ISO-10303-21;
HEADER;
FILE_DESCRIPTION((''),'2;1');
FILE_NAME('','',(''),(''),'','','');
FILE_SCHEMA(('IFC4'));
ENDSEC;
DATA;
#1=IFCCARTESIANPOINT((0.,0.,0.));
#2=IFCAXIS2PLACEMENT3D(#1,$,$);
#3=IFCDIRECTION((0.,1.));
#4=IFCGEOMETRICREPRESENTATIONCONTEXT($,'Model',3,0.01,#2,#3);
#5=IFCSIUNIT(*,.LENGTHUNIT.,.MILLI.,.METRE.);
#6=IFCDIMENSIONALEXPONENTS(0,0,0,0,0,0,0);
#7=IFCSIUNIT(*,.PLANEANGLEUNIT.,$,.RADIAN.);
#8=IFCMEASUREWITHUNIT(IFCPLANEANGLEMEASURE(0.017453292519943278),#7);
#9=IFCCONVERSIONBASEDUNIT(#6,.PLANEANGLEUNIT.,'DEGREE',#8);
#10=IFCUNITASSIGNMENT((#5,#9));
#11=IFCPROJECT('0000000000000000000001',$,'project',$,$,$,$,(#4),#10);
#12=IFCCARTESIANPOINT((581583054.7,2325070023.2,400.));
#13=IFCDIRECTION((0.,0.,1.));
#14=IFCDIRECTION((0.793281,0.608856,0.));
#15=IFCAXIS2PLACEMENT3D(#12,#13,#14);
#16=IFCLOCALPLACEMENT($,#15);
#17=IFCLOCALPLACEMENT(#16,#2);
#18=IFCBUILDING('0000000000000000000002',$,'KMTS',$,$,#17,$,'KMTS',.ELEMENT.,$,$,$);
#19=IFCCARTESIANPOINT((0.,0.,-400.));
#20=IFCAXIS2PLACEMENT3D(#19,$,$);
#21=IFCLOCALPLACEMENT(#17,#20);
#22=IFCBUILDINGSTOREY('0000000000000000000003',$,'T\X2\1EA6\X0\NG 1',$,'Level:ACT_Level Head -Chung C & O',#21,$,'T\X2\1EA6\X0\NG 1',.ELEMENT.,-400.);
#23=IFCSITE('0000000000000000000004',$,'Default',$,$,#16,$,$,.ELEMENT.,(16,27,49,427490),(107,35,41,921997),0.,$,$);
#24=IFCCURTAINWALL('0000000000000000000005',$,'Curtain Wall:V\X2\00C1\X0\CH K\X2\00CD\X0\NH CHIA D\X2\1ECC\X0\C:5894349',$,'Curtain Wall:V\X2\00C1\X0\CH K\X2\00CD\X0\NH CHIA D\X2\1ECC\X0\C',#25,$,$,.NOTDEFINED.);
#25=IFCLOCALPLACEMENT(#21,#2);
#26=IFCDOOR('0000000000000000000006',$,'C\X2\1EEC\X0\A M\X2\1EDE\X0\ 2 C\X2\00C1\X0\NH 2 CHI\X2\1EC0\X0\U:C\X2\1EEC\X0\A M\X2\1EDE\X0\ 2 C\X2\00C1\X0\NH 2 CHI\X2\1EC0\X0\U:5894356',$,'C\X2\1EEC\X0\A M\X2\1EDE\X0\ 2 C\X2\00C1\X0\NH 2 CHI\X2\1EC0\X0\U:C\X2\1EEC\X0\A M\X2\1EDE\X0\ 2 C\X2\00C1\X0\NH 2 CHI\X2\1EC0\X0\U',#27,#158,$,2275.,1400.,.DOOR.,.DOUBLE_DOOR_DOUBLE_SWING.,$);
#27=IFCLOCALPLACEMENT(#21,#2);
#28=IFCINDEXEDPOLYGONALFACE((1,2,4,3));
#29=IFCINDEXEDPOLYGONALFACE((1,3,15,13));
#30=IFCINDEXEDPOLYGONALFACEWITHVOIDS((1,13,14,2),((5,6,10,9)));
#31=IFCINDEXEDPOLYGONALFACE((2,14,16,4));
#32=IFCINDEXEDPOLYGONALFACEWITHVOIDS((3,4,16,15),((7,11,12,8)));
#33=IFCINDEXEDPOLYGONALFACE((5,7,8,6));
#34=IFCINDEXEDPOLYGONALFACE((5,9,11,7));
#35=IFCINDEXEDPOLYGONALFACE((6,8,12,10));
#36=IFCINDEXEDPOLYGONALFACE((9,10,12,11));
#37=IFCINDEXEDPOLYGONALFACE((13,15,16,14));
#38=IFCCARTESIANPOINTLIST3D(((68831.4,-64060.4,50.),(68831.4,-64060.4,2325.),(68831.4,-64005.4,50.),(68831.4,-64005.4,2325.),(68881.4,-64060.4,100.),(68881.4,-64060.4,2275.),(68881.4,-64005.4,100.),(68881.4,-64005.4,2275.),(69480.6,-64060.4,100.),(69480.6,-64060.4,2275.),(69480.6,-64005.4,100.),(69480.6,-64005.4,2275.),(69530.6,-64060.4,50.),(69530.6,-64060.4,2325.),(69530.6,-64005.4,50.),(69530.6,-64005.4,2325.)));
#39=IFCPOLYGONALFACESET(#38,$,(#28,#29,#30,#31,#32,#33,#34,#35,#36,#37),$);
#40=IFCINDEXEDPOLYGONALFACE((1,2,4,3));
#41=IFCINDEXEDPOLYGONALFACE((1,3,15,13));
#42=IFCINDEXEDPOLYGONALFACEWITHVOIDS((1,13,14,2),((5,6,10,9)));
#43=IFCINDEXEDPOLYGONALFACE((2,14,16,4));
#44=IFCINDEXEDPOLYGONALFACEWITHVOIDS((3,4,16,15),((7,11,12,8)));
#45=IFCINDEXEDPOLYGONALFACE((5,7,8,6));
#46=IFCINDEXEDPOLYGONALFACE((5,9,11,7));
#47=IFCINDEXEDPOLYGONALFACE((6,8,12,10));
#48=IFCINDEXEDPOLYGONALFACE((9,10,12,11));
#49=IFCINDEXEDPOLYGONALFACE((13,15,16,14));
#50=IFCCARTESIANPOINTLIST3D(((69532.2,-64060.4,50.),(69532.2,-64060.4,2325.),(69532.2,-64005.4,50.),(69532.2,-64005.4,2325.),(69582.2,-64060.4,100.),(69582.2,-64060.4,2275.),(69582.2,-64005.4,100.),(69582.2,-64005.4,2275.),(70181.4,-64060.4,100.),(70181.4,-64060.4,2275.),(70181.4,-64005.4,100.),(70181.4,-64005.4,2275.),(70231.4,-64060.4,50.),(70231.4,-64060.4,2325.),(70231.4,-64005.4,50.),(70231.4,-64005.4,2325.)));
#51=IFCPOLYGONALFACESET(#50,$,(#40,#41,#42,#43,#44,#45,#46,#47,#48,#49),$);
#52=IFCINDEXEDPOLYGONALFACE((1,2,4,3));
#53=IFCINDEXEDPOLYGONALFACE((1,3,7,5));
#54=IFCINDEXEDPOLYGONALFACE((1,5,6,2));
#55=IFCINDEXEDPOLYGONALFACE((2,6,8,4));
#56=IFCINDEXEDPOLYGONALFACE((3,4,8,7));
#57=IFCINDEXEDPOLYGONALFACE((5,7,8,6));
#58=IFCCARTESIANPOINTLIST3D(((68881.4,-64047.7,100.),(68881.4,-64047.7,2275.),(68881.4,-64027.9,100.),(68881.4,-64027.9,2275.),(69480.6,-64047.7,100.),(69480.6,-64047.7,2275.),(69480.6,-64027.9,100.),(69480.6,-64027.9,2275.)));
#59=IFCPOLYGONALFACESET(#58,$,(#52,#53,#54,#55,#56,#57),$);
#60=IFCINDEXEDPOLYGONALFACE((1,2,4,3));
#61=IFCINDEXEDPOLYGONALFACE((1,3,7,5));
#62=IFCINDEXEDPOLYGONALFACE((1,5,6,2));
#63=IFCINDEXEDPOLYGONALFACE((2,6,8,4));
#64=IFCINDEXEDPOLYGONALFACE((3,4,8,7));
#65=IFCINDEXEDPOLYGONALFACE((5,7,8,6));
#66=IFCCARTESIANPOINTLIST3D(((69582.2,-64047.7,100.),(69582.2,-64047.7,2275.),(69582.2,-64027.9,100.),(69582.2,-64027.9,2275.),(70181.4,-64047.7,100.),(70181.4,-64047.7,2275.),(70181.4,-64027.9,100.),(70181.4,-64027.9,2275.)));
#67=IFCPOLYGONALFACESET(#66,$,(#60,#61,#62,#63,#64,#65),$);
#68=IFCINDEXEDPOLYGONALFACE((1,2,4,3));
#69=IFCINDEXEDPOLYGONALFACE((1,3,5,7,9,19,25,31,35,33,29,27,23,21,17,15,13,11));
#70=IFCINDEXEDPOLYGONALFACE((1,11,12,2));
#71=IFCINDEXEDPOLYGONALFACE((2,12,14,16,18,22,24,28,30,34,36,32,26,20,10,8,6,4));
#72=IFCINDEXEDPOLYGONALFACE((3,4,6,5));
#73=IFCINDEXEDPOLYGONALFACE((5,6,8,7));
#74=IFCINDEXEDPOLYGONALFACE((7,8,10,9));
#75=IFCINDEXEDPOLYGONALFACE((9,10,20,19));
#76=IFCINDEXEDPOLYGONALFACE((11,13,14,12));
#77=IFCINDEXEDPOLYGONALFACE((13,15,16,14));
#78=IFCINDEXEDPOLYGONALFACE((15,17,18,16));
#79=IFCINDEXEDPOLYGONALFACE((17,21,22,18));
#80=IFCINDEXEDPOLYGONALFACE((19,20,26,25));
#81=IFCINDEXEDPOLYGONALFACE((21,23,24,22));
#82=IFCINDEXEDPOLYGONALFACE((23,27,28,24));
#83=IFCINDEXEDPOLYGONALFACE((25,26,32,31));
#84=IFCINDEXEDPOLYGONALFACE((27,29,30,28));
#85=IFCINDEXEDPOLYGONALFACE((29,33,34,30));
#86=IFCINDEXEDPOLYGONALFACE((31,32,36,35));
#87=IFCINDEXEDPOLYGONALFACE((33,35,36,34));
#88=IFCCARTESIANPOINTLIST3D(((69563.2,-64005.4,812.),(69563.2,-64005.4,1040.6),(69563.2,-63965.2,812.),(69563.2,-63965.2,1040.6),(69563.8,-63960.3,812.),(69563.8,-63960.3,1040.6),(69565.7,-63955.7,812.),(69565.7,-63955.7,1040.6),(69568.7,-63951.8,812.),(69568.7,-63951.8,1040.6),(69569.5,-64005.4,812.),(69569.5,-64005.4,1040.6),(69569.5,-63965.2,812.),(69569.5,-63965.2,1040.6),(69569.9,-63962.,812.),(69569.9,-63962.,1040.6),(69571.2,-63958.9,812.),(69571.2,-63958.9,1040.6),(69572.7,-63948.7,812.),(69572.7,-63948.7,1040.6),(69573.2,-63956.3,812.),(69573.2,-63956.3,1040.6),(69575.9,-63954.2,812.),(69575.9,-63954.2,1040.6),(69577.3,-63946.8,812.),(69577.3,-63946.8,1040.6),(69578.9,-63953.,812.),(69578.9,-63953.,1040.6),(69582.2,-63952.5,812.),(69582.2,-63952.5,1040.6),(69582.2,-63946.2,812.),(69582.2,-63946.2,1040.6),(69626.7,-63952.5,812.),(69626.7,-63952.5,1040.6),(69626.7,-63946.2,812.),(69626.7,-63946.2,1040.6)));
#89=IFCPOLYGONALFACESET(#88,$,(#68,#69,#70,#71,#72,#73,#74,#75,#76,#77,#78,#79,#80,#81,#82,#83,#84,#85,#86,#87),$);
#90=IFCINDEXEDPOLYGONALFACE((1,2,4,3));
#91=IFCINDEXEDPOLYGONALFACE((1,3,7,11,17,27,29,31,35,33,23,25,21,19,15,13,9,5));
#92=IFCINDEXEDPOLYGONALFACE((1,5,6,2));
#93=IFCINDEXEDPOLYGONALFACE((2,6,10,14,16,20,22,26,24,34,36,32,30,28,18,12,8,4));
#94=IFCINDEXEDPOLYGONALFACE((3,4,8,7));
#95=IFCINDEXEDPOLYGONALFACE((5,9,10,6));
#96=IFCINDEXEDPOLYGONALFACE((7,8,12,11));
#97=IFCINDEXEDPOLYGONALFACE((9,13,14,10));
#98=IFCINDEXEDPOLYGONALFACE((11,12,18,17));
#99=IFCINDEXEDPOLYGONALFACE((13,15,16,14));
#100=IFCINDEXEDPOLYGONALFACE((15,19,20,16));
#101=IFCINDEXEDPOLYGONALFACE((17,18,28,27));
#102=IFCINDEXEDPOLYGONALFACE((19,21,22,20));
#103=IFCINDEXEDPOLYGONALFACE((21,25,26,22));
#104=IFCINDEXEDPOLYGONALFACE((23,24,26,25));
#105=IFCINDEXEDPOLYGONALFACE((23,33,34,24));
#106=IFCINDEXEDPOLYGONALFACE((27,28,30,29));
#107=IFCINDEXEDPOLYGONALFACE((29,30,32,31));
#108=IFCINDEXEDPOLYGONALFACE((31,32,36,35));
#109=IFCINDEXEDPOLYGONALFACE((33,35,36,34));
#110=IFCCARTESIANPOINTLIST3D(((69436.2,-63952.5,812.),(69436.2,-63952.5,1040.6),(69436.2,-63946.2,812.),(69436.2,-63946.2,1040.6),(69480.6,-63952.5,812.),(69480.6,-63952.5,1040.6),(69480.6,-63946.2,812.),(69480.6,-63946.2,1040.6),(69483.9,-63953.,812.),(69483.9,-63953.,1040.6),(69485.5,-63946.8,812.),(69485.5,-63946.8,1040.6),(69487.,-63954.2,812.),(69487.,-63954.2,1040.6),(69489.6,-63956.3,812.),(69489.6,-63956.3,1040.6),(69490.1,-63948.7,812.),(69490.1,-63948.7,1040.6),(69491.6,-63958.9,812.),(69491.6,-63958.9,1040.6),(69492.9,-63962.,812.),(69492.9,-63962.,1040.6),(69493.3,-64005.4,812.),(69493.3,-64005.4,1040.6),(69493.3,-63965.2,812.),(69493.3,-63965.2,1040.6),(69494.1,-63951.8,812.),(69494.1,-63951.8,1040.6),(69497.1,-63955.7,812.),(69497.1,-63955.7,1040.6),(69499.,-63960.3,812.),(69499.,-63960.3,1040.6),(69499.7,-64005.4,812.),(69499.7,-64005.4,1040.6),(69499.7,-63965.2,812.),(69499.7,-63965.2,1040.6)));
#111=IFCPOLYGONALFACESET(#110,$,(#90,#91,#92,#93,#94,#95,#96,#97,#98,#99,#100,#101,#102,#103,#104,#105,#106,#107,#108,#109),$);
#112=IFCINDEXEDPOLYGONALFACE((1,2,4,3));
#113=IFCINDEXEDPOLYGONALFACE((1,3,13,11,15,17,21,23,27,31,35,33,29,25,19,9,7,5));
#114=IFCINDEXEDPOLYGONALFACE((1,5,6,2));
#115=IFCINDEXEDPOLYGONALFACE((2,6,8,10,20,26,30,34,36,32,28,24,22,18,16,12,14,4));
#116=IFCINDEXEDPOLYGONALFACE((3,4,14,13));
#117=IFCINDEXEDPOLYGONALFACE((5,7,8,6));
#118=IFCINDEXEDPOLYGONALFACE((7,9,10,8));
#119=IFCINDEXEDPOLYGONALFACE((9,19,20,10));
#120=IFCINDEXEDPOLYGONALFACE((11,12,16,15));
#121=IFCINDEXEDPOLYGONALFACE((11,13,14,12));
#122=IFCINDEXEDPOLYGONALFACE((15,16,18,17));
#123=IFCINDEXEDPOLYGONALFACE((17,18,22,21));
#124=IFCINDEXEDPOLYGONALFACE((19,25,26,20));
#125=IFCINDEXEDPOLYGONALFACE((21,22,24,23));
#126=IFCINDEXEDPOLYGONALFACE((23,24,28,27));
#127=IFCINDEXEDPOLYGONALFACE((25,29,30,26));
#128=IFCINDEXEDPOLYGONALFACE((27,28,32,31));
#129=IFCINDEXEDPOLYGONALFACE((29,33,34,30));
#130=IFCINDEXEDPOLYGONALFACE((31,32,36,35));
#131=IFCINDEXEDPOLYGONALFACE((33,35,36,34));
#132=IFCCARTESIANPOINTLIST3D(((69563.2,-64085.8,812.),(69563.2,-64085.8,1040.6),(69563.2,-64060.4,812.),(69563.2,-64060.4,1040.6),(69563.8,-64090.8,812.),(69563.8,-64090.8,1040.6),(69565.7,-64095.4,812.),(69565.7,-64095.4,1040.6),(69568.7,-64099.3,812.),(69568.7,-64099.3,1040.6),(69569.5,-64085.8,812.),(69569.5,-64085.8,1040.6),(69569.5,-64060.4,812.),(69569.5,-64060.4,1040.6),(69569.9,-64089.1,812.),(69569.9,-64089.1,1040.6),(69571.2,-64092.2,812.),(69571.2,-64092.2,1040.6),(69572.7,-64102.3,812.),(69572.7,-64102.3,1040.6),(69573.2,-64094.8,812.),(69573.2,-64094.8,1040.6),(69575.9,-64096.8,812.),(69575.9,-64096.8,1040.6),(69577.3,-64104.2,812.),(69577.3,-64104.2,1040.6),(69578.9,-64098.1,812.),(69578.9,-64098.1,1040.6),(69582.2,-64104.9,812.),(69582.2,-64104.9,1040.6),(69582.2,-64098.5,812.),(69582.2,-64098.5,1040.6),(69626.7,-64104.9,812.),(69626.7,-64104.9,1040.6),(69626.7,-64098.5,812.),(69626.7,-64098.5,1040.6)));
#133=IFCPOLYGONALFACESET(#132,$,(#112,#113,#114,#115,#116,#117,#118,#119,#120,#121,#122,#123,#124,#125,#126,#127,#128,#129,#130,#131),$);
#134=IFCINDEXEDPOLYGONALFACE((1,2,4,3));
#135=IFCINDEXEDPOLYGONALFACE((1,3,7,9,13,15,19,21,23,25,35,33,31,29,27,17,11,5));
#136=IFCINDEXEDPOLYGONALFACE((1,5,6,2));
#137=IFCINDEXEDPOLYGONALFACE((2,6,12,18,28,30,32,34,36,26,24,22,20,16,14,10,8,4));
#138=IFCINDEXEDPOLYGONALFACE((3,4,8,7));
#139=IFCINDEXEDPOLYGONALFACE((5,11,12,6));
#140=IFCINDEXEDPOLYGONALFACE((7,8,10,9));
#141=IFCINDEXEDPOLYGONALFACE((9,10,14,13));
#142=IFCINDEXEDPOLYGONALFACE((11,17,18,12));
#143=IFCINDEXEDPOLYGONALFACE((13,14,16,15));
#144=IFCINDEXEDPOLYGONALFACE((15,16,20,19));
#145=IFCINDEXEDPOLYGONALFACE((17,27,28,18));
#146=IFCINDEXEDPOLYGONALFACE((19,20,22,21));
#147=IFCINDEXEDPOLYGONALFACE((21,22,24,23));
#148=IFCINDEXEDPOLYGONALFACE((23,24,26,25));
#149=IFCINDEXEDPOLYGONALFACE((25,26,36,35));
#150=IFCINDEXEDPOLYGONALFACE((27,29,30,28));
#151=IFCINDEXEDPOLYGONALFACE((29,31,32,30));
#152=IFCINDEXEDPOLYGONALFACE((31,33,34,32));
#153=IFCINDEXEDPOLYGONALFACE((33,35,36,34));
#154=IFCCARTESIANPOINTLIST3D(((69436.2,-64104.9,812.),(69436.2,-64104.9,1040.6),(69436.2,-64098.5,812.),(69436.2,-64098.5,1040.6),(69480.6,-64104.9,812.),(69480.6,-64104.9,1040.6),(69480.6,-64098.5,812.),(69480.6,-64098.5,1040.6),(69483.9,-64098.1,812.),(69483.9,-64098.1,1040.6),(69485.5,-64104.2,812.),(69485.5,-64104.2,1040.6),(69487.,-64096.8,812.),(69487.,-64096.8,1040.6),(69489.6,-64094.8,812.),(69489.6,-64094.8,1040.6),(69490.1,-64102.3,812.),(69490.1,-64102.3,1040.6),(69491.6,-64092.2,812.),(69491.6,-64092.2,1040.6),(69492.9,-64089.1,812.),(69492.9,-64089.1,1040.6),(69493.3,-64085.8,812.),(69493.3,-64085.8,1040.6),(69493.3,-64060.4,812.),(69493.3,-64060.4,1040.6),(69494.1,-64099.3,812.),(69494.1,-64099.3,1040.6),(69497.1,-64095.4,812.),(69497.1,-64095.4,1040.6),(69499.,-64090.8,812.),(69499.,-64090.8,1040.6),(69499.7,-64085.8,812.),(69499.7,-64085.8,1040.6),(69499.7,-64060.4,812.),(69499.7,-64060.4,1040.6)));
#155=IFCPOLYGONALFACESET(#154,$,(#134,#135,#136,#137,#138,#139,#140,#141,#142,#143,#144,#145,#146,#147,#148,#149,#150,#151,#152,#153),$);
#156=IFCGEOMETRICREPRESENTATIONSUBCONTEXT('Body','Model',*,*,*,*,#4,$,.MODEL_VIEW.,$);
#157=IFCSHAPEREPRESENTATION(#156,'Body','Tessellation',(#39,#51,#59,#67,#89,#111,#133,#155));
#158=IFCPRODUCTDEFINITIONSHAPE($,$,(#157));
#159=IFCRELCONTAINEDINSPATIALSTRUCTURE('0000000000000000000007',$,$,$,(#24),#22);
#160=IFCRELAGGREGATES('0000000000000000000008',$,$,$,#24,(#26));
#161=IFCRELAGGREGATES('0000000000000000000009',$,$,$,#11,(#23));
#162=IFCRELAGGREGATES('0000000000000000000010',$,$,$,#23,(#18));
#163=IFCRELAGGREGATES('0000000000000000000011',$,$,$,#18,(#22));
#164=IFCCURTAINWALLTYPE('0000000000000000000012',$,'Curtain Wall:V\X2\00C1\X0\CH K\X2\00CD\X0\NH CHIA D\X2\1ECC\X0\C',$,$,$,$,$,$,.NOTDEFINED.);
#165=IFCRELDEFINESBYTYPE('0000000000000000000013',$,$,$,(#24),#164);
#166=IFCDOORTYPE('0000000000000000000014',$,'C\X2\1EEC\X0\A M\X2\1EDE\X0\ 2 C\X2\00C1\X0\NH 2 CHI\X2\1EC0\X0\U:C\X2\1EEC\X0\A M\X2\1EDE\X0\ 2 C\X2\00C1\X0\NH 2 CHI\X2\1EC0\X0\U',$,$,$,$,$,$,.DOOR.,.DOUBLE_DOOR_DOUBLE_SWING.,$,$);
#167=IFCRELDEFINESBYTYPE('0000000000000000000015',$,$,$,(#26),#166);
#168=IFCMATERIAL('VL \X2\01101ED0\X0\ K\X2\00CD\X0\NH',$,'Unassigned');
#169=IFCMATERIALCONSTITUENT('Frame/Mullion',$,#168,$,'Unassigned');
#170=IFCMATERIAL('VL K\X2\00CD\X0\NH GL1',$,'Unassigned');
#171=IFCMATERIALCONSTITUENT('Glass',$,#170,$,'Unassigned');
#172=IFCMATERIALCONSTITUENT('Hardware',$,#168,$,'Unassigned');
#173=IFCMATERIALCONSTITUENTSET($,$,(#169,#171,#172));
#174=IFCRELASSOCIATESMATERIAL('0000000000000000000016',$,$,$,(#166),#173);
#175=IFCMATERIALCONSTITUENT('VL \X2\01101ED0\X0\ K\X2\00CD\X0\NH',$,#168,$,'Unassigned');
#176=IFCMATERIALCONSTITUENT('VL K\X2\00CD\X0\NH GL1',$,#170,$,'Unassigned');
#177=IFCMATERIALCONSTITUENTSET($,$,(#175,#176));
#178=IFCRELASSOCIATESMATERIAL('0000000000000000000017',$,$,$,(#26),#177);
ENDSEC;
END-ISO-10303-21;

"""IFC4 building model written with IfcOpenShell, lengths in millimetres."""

from ifc_helpers import new_model, entity, si_unit, converted_unit, direction, frame, origin, place, context, subcontext, project, spatial, line, arc, indexed_curve, outline, extrude, source, transform, mapped, material, constituent, constituent_set, type_object, type_shapes, element, aggregate, save


model = new_model("IFC4")

# Units and contexts
model_context = context("Model", 3, precision=0.01, world=origin(), true_north=direction((0.0, 1.0)))
body_context = subcontext(model_context, "Body", "Model", "MODEL_VIEW")
ifc_project = project(units=[si_unit("LENGTHUNIT", "METRE", prefix="MILLI"), converted_unit("PLANEANGLEUNIT", "DEGREE", entity("IfcPlaneAngleMeasure", 0.017453292519943278), si_unit("PLANEANGLEUNIT", "RADIAN"), dimensions=[0, 0, 0, 0, 0, 0, 0])], contexts=[model_context])

# Site, building, storey
site_placement = place(None, frame((581583054.7, 2325070023.2, 400.0), z_axis=(0.0, 0.0, 1.0), x_axis=(0.793281, 0.608856, 0.0)))
site = spatial("IfcSite", under=ifc_project, at=site_placement, Name="Default", CompositionType="ELEMENT", RefLatitude=(16, 27, 49, 427490), RefLongitude=(107, 35, 41, 921997), RefElevation=0.0)
building_placement = place(site_placement, origin())
building = spatial("IfcBuilding", under=site, at=building_placement, Name="KMTS", LongName="KMTS", CompositionType="ELEMENT")
storey_placement = place(building_placement, frame((0.0, 0.0, -400.0)))
storey = spatial("IfcBuildingStorey", under=building, at=storey_placement, Name="TẦNG 1", ObjectType="Level:ACT_Level Head -Chung C & O", LongName="TẦNG 1", CompositionType="ELEMENT", Elevation=-400.0)

# Curtain wall
curtain_wall_type = type_object("IfcCurtainWallType", Name="Curtain Wall:VÁCH KÍNH CHIA DỌC", PredefinedType="NOTDEFINED")
curtain_wall_1_placement = place(storey_placement, frame((0.0, 0.0, 400.0)))
curtain_wall_1 = element("IfcCurtainWall", 1, at=curtain_wall_1_placement, inside=storey, type_object=curtain_wall_type, Name="Curtain Wall:VÁCH KÍNH CHIA DỌC:5894349", ObjectType="Curtain Wall:VÁCH KÍNH CHIA DỌC", PredefinedType="NOTDEFINED")
ifc_material_1 = material(Name="VL ĐỐ KÍNH", Category="Unassigned")

# Door
ifc_constituent_1 = constituent(ifc_material_1, Name="VL ĐỐ KÍNH", Category="Unassigned")
ifc_material_2 = material(Name="VL KÍNH GL1", Category="Unassigned")
ifc_constituent_2 = constituent(ifc_material_2, Name="VL KÍNH GL1", Category="Unassigned")
ifc_constituent_set_1 = constituent_set(constituents=[ifc_constituent_1, ifc_constituent_2])
ifc_constituent_3 = constituent(ifc_material_1, Name="Frame/Mullion", Category="Unassigned")
ifc_constituent_4 = constituent(ifc_material_2, Name="Glass", Category="Unassigned")
ifc_constituent_5 = constituent(ifc_material_1, Name="Hardware", Category="Unassigned")
ifc_constituent_set_2 = constituent_set(constituents=[ifc_constituent_3, ifc_constituent_4, ifc_constituent_5])
door_type_1 = type_object("IfcDoorType", Name="CỬA MỞ 2 CÁNH 2 CHIỀU:CỬA MỞ 2 CÁNH 2 CHIỀU", OperationType="DOUBLE_DOOR_DOUBLE_SWING", PredefinedType="DOOR", material=ifc_constituent_set_2)
shared_shape_1 = source(origin(), body_context, "Body", "SweptSolid", [
    extrude(outline(indexed_curve([(-1137.5, -349.6), (1137.5, -349.6), (1137.5, 349.6), (-1137.5, 349.6), (-1137.5, -349.6)], self_intersect=False), holes=[indexed_curve([(-1087.5, 299.6), (1087.5, 299.6), (1087.5, -299.6), (-1087.5, -299.6), (-1087.5, 299.6)], self_intersect=False)]), frame((350.4, 27.5, 1137.5), z_axis=(0.0, -1.0, 0.0), x_axis=(0.0, 0.0, -1.0)), (0.0, 0.0, 1.0), 55.0),
    extrude(outline(indexed_curve([(-349.6, -1137.5), (349.6, -1137.5), (349.6, 1137.5), (-349.6, 1137.5), (-349.6, -1137.5)], self_intersect=False), holes=[indexed_curve([(-299.6, -1087.5), (-299.6, 1087.5), (299.6, 1087.5), (299.6, -1087.5), (-299.6, -1087.5)], self_intersect=False)]), frame((-350.4, 27.5, 1137.5), z_axis=(0.0, -1.0, 0.0), x_axis=(-1.0, 0.0, 0.0)), (0.0, 0.0, 1.0), 55.0),
    extrude(outline(indexed_curve([(-299.6, -9.9), (299.6, -9.9), (299.6, 9.9), (-299.6, 9.9), (-299.6, -9.9)], self_intersect=False)), frame((350.4, 4.9, 50.0)), (0.0, 0.0, 1.0), 2175.0),
    extrude(outline(indexed_curve([(-299.6, -9.9), (299.6, -9.9), (299.6, 9.9), (-299.6, 9.9), (-299.6, -9.9)], self_intersect=False)), frame((-350.4, 4.9, 50.0)), (0.0, 0.0, 1.0), 2175.0),
    extrude(outline(indexed_curve([(-2.1, -22.2), (38.1, -22.2), (38.1, -15.9), (-2.1, -15.9), (-11.1, -12.2), (-14.8, -3.2), (-14.8, 41.3), (-21.2, 41.3), (-21.2, -3.2), (-15.6, -16.6)], segments=[line(1, 2, 3, 4), arc(4, 5, 6), line(6, 7, 8, 9), arc(9, 10, 1)], self_intersect=False)), frame((-54.0, -65.6, 762.0), z_axis=(0.0, 0.0, 1.0), x_axis=(0.0, 1.0, 0.0)), (0.0, 0.0, 1.0), 228.6),
    extrude(outline(indexed_curve([(22.2, 2.1), (16.6, 15.6), (3.2, 21.2), (-41.3, 21.2), (-41.3, 14.8), (3.2, 14.8), (12.2, 11.1), (15.9, 2.1), (15.9, -38.1), (22.2, -38.1)], segments=[arc(1, 2, 3), line(3, 4, 5, 6), arc(6, 7, 8), line(8, 9, 10, 1)], self_intersect=False)), frame((54.0, -65.6, 762.0), z_axis=(0.0, 0.0, 1.0), x_axis=(-1.0, 0.0, 0.0)), (0.0, 0.0, 1.0), 228.6),
    extrude(outline(indexed_curve([(-22.2, 1.6), (-16.6, -11.9), (-3.2, -17.5), (41.3, -17.5), (41.3, -11.1), (-3.2, -11.1), (-12.2, -7.4), (-15.9, 1.6), (-15.9, 27.0), (-22.2, 27.0)], segments=[arc(1, 2, 3), line(3, 4, 5, 6), arc(6, 7, 8), line(8, 9, 10, 1)], self_intersect=False)), frame((-54.0, 54.5, 762.0), z_axis=(0.0, 0.0, 1.0), x_axis=(-1.0, 0.0, 0.0)), (0.0, 0.0, 1.0), 228.6),
    extrude(outline(indexed_curve([(1.6, -22.2), (27.0, -22.2), (27.0, -15.9), (1.6, -15.9), (-7.4, -12.2), (-11.1, -3.2), (-11.1, 41.3), (-17.5, 41.3), (-17.5, -3.2), (-11.9, -16.6)], segments=[line(1, 2, 3, 4), arc(4, 5, 6), line(6, 7, 8, 9), arc(9, 10, 1)], self_intersect=False)), frame((54.0, 54.5, 762.0), z_axis=(0.0, 0.0, 1.0), x_axis=(0.0, -1.0, 0.0)), (0.0, 0.0, 1.0), 228.6),
])
type_shapes(door_type_1, [shared_shape_1])
door_1_placement = place(curtain_wall_1_placement, frame((69531.4, -64032.9, -350.0), z_axis=(0.0, 0.0, 1.0), x_axis=(-1.0, 0.0, 0.0)))
door_1 = element("IfcDoor", 2, at=door_1_placement, type_object=door_type_1, material=ifc_constituent_set_1, Name="CỬA MỞ 2 CÁNH 2 CHIỀU:CỬA MỞ 2 CÁNH 2 CHIỀU:5894356", ObjectType="CỬA MỞ 2 CÁNH 2 CHIỀU:CỬA MỞ 2 CÁNH 2 CHIỀU", OperationType="DOUBLE_DOOR_DOUBLE_SWING", OverallHeight=2275.0, OverallWidth=1400.0, PredefinedType="DOOR", context=body_context, shape_type="MappedRepresentation", body=[
    mapped(shared_shape_1, transform((0.0, 0.0, 0.0), scale=1.0)),
])
aggregate(curtain_wall_1, [door_1])

save(model, "model.ifc")
